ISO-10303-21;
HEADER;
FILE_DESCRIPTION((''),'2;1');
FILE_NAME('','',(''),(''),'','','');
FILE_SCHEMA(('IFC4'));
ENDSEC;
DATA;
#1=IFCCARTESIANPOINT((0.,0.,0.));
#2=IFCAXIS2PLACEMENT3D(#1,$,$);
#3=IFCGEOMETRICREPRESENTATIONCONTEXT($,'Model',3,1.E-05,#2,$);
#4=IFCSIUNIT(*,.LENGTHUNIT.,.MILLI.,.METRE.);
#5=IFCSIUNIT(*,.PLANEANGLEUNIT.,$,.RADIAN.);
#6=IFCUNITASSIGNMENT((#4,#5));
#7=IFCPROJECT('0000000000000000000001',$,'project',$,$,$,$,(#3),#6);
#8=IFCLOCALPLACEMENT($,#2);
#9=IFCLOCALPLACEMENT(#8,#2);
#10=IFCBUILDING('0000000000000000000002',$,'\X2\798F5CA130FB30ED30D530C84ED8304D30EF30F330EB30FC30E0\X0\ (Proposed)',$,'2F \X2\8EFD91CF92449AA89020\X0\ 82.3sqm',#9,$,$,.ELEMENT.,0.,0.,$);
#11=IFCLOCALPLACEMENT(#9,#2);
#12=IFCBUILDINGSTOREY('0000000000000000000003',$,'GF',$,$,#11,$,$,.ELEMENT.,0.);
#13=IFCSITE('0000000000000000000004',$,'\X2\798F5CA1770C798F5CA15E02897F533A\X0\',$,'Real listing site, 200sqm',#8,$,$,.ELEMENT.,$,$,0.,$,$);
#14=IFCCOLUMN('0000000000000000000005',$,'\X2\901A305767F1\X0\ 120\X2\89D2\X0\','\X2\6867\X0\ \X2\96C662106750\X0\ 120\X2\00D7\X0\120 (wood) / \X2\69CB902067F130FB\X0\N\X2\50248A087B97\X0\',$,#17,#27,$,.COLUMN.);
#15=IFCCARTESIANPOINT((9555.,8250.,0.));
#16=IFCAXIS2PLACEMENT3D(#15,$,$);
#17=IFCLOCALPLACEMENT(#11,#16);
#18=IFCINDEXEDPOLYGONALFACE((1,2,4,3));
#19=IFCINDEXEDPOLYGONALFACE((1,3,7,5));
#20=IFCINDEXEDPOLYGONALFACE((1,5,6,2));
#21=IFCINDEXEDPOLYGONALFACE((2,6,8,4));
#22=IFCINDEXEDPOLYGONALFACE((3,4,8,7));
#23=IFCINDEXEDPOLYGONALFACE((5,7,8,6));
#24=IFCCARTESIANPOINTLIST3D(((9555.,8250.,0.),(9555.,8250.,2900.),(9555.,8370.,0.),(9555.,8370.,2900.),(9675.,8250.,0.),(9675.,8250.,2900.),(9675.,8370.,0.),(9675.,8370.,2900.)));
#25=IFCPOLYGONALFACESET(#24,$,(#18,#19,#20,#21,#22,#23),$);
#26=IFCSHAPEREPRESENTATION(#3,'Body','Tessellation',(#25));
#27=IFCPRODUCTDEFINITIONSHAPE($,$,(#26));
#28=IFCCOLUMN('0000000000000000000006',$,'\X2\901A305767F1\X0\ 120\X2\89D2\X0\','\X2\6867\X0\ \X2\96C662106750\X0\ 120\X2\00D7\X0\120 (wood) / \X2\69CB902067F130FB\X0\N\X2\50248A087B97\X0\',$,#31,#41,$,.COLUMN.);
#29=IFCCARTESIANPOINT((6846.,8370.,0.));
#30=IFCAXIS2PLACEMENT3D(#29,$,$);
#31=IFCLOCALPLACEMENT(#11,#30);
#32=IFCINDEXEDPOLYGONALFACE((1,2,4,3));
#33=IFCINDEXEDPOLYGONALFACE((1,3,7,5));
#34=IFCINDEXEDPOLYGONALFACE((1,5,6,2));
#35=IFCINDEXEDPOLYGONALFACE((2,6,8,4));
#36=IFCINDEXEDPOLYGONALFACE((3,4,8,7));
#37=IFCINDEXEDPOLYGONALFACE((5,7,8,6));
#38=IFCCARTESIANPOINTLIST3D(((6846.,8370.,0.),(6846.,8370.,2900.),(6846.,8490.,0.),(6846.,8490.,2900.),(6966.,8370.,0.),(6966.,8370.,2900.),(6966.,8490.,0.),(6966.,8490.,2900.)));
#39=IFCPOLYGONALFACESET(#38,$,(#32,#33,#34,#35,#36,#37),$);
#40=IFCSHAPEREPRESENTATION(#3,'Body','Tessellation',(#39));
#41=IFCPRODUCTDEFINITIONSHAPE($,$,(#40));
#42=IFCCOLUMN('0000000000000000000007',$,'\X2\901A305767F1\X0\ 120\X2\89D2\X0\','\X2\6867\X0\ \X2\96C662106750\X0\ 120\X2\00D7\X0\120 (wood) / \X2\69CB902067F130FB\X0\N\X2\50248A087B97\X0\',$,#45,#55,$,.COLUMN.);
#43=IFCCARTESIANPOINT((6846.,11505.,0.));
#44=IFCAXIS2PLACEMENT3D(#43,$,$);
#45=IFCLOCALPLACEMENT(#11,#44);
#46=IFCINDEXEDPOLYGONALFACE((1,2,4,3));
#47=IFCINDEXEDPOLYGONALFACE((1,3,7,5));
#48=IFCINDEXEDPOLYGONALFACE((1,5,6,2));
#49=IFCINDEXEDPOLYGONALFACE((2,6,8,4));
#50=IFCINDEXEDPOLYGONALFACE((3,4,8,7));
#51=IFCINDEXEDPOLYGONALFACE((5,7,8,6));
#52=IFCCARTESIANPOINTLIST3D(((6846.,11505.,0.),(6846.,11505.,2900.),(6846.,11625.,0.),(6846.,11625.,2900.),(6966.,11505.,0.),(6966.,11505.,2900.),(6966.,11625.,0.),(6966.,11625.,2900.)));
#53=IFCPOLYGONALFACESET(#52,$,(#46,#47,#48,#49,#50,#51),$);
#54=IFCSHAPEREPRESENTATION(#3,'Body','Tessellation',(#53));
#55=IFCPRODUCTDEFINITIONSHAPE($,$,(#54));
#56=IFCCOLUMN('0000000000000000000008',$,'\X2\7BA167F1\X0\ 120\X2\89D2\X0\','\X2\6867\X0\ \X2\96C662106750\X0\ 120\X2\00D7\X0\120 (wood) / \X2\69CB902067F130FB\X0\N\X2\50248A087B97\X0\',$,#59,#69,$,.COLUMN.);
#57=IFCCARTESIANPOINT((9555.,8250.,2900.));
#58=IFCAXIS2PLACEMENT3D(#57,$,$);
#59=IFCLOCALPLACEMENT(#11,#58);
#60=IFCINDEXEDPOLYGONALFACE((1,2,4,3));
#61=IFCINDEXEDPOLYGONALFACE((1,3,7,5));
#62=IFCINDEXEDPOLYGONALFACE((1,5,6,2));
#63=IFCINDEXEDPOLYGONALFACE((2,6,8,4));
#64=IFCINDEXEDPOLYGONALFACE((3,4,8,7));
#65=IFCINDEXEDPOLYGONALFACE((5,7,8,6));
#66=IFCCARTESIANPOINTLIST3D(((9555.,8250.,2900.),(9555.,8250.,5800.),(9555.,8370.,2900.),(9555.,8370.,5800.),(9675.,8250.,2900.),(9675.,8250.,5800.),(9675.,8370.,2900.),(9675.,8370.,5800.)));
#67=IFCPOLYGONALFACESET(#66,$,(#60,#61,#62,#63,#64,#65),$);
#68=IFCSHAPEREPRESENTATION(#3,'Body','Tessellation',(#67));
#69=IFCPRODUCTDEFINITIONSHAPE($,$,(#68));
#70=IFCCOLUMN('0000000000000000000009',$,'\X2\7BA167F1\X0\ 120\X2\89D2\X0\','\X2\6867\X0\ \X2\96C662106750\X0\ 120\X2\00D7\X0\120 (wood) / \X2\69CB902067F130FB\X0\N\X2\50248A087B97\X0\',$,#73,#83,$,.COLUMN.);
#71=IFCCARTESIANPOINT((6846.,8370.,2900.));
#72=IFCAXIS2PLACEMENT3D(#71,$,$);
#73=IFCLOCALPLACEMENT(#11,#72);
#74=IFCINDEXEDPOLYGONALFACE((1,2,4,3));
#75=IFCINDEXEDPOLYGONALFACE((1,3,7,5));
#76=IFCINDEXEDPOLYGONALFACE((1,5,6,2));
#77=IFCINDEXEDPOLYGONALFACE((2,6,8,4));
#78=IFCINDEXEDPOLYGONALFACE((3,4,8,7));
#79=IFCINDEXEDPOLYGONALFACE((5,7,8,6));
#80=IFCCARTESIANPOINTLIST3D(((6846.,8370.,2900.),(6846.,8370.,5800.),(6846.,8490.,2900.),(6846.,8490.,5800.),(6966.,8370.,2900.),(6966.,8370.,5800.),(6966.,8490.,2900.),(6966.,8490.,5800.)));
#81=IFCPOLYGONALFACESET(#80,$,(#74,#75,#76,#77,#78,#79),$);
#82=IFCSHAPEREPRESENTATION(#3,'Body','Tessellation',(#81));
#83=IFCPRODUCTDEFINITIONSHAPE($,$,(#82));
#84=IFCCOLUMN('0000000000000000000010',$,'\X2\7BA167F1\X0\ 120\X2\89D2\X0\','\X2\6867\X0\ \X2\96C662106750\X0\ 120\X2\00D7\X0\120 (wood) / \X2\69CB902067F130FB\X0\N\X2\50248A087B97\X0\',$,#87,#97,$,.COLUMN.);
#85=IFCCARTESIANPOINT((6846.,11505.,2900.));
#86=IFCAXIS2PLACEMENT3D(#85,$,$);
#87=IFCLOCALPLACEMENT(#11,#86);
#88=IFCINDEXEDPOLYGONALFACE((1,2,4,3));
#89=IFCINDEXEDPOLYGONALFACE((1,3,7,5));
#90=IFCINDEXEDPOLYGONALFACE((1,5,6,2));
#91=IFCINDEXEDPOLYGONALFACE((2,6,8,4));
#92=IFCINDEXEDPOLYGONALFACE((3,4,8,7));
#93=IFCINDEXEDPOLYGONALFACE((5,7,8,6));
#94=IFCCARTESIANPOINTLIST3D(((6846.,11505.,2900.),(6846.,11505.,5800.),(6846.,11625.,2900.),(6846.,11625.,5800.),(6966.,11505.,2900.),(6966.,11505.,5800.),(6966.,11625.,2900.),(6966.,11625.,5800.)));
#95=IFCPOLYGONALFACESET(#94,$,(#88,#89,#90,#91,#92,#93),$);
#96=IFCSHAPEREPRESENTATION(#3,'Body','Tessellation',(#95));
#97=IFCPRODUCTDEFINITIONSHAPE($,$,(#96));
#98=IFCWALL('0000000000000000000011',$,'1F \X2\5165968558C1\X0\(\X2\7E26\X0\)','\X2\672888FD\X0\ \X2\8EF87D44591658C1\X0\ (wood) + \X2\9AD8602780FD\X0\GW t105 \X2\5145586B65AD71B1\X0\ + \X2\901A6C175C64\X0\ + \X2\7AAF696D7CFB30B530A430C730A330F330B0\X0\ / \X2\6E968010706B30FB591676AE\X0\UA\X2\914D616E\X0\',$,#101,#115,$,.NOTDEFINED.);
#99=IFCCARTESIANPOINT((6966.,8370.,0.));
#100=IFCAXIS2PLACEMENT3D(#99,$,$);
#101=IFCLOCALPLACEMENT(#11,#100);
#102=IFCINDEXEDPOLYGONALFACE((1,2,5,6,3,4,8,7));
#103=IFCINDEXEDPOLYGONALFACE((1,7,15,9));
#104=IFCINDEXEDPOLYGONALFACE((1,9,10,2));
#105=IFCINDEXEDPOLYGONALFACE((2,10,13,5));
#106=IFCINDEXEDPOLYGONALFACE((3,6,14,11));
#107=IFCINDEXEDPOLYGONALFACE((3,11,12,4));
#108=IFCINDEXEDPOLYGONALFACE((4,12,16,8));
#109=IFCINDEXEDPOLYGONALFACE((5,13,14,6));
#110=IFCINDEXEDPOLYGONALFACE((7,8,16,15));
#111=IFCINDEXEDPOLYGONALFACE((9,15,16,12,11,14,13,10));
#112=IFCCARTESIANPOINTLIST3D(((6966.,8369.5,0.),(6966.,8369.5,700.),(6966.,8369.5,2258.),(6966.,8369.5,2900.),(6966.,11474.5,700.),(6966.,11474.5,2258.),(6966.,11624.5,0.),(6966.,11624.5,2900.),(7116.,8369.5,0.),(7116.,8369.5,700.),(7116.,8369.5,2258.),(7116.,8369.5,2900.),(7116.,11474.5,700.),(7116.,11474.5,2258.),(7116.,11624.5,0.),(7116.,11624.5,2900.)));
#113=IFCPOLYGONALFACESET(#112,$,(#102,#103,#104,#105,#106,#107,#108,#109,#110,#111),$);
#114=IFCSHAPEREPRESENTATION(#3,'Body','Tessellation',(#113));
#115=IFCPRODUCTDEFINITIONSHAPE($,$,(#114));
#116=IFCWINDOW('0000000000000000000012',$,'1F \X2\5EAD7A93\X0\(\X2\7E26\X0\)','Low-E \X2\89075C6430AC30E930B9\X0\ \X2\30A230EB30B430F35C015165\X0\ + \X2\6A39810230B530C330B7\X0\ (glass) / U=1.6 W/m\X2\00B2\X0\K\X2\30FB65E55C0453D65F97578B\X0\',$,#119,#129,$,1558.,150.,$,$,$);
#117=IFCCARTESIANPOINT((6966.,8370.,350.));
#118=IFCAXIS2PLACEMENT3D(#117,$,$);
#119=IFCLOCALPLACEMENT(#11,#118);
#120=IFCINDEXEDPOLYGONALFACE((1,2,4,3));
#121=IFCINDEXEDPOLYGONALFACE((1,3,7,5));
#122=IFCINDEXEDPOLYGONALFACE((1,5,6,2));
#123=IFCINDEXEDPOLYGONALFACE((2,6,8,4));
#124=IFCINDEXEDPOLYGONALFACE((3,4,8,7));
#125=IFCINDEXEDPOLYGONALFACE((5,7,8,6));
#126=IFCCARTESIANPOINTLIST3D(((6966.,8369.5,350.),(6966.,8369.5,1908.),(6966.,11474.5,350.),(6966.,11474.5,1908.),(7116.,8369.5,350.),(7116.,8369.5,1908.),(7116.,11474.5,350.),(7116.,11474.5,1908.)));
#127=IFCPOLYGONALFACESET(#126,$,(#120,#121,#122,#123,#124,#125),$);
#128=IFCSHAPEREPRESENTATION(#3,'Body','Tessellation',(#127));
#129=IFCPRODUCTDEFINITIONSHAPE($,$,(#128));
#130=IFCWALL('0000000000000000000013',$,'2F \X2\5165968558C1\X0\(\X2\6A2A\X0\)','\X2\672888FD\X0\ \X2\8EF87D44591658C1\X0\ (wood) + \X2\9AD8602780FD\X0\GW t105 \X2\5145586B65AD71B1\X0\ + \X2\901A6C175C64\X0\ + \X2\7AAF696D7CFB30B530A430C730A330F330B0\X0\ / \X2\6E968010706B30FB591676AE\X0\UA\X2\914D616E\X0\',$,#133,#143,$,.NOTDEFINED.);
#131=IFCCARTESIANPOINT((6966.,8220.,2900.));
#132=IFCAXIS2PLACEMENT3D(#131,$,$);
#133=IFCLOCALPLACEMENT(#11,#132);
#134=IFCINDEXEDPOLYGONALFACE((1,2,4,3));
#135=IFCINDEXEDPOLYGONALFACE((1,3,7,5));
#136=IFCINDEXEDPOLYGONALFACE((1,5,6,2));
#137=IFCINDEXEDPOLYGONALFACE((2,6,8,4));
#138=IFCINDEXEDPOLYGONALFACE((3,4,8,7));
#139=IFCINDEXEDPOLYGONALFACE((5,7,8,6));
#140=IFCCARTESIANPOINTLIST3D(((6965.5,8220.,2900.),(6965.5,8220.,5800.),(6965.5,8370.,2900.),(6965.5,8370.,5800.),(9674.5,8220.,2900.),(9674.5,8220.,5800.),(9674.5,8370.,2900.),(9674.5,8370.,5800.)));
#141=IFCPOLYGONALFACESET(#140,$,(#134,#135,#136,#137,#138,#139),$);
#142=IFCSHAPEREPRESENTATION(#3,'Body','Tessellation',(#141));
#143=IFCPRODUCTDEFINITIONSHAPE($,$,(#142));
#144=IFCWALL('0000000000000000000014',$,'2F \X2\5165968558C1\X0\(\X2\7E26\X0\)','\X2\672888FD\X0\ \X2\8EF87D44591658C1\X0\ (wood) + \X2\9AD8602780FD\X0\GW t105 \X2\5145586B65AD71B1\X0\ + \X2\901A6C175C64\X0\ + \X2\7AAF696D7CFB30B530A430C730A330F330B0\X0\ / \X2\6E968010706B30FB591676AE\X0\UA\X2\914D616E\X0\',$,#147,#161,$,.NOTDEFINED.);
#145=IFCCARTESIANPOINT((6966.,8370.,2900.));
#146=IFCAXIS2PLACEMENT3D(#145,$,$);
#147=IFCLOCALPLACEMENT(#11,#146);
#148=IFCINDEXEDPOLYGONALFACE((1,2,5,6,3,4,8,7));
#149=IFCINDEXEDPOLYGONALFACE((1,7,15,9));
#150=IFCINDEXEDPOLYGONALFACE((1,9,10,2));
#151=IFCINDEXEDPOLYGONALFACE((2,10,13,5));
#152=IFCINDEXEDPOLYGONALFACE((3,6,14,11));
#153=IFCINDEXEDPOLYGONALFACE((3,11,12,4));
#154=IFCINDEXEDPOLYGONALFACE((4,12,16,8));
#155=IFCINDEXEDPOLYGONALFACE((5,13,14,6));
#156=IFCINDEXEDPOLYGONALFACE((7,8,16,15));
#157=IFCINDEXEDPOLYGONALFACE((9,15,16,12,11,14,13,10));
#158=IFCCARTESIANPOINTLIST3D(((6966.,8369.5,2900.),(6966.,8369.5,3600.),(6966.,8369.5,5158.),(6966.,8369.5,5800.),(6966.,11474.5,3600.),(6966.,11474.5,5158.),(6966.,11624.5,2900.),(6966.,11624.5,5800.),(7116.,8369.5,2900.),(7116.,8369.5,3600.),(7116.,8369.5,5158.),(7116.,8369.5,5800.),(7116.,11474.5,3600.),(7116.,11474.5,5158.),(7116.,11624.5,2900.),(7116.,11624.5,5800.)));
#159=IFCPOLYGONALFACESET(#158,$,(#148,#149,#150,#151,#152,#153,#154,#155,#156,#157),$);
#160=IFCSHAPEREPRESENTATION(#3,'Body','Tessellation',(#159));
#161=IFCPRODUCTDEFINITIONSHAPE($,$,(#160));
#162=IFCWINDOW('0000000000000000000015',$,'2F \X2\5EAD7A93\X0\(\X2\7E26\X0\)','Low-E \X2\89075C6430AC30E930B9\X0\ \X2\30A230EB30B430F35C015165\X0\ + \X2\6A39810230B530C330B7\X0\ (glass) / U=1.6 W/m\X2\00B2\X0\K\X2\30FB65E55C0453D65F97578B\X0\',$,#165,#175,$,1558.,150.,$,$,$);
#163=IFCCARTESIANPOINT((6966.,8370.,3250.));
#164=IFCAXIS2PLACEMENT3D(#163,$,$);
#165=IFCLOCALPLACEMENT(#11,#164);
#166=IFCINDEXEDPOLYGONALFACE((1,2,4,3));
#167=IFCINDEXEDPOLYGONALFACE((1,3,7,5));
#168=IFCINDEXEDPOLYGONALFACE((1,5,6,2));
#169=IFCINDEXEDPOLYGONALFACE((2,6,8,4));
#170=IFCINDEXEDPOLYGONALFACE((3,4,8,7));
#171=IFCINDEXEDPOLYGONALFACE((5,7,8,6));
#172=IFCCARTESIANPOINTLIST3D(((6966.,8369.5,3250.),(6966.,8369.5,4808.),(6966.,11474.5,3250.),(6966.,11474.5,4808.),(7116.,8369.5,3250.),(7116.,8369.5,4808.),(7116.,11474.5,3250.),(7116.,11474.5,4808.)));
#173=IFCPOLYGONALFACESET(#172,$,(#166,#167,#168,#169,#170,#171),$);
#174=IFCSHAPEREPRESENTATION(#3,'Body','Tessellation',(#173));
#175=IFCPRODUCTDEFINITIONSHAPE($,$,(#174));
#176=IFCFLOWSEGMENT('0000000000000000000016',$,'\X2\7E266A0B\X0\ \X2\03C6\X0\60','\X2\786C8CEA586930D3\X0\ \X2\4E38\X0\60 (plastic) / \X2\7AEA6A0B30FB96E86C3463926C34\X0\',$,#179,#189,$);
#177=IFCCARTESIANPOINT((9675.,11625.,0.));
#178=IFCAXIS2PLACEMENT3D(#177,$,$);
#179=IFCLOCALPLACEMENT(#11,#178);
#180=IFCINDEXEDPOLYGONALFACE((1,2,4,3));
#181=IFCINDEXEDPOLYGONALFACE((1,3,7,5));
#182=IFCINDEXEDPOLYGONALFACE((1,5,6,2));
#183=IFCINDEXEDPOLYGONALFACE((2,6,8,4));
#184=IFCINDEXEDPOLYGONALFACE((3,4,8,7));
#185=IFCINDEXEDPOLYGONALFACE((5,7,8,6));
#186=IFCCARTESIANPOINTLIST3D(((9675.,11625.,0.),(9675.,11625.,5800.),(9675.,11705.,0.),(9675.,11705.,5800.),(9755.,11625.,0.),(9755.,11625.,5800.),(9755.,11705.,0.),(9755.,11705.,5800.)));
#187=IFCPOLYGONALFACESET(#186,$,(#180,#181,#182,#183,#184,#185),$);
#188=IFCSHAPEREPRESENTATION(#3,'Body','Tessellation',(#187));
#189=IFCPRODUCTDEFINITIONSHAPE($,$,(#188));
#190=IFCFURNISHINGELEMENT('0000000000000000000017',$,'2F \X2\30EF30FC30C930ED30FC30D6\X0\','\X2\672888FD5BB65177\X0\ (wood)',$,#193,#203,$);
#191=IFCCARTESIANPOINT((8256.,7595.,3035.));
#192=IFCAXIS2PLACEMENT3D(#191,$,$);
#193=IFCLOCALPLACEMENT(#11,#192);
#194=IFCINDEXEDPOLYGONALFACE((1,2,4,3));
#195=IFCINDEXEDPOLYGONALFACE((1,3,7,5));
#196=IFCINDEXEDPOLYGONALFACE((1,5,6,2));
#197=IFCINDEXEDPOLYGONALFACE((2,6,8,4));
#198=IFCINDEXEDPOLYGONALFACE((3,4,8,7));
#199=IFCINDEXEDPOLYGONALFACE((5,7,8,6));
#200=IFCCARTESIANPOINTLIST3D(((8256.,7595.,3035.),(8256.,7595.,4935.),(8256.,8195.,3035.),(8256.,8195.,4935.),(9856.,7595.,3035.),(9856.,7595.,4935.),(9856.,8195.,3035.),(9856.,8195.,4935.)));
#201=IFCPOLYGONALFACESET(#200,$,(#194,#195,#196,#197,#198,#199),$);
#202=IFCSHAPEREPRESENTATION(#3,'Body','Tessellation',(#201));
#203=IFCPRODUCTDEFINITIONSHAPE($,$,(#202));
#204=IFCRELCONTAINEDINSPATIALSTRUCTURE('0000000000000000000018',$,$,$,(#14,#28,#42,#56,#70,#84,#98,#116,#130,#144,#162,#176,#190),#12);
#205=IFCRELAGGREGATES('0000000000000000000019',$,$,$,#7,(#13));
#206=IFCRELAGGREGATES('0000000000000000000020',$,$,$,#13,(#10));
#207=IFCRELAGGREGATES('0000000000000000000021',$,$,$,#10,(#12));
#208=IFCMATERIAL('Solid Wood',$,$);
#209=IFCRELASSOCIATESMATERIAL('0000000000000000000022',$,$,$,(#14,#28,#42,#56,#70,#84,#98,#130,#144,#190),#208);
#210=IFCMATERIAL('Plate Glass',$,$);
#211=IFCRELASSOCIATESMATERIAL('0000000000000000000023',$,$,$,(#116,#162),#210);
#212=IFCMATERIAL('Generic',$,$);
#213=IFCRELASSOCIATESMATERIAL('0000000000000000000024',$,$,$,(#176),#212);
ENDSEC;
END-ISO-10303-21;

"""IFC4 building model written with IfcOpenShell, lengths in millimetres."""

from ifc_helpers import new_model, si_unit, frame, frame_2d, origin, place, context, project, spatial, rectangle, extrude, material, element, fill, save


model = new_model("IFC4")

# Units and contexts
model_context = context("Model", 3, precision=1e-05, world=origin())
ifc_project = project(units=[si_unit("LENGTHUNIT", "METRE", prefix="MILLI"), si_unit("PLANEANGLEUNIT", "RADIAN")], contexts=[model_context])

# Site, building, storey
site_placement = place(None, origin())
site = spatial("IfcSite", under=ifc_project, at=site_placement, Name="福岡県福岡市西区", ObjectType="Real listing site, 200sqm", CompositionType="ELEMENT", RefElevation=0.0)
building_placement = place(site_placement, origin())
building = spatial("IfcBuilding", under=site, at=building_placement, Name="福岡・ロフト付きワンルーム (Proposed)", ObjectType="2F 軽量鉄骨造 82.3sqm", CompositionType="ELEMENT", ElevationOfRefHeight=0.0, ElevationOfTerrain=0.0)
storey_placement = place(building_placement, origin())
storey = spatial("IfcBuildingStorey", under=building, at=storey_placement, Name="GF", CompositionType="ELEMENT", Elevation=0.0)

# Columns
ifc_material_1 = material(Name="Solid Wood")
column_1_placement = place(storey_placement, frame((9555.0, 8250.0, 0.0)))
element("IfcColumn", 1, at=column_1_placement, inside=storey, material=ifc_material_1, Name="通し柱 120角", Description="桧 集成材 120×120 (wood) / 構造柱・N値計算", PredefinedType="COLUMN", context=model_context, shape_type="SweptSolid", body=[
    extrude(rectangle(XDim=120.0, YDim=120.0, at=frame_2d((60.0, 60.0))), frame((9555.0, 8250.0, 0.0)), (0.0, 0.0, 1.0), 2900.0),
])
column_2_placement = place(storey_placement, frame((6846.0, 8370.0, 0.0)))
element("IfcColumn", 2, at=column_2_placement, inside=storey, material=ifc_material_1, Name="通し柱 120角", Description="桧 集成材 120×120 (wood) / 構造柱・N値計算", PredefinedType="COLUMN", context=model_context, shape_type="SweptSolid", body=[
    extrude(rectangle(XDim=120.0, YDim=120.0, at=frame_2d((60.0, 60.0))), frame((6846.0, 8370.0, 0.0)), (0.0, 0.0, 1.0), 2900.0),
])
column_3_placement = place(storey_placement, frame((6846.0, 11505.0, 0.0)))
element("IfcColumn", 3, at=column_3_placement, inside=storey, material=ifc_material_1, Name="通し柱 120角", Description="桧 集成材 120×120 (wood) / 構造柱・N値計算", PredefinedType="COLUMN", context=model_context, shape_type="SweptSolid", body=[
    extrude(rectangle(XDim=120.0, YDim=120.0, at=frame_2d((60.0, 60.0))), frame((6846.0, 11505.0, 0.0)), (0.0, 0.0, 1.0), 2900.0),
])
column_4_placement = place(storey_placement, frame((9555.0, 8250.0, 2900.0)))
element("IfcColumn", 4, at=column_4_placement, inside=storey, material=ifc_material_1, Name="管柱 120角", Description="桧 集成材 120×120 (wood) / 構造柱・N値計算", PredefinedType="COLUMN", context=model_context, shape_type="SweptSolid", body=[
    extrude(rectangle(XDim=120.0, YDim=120.0, at=frame_2d((60.0, 60.0))), frame((9555.0, 8250.0, 2900.0)), (0.0, 0.0, 1.0), 2900.0),
])
column_5_placement = place(storey_placement, frame((6846.0, 8370.0, 2900.0)))
element("IfcColumn", 5, at=column_5_placement, inside=storey, material=ifc_material_1, Name="管柱 120角", Description="桧 集成材 120×120 (wood) / 構造柱・N値計算", PredefinedType="COLUMN", context=model_context, shape_type="SweptSolid", body=[
    extrude(rectangle(XDim=120.0, YDim=120.0, at=frame_2d((60.0, 60.0))), frame((6846.0, 8370.0, 2900.0)), (0.0, 0.0, 1.0), 2900.0),
])
column_6_placement = place(storey_placement, frame((6846.0, 11505.0, 2900.0)))
element("IfcColumn", 6, at=column_6_placement, inside=storey, material=ifc_material_1, Name="管柱 120角", Description="桧 集成材 120×120 (wood) / 構造柱・N値計算", PredefinedType="COLUMN", context=model_context, shape_type="SweptSolid", body=[
    extrude(rectangle(XDim=120.0, YDim=120.0, at=frame_2d((60.0, 60.0))), frame((6846.0, 11505.0, 2900.0)), (0.0, 0.0, 1.0), 2900.0),
])

# Wall, opening, window
wall_1_placement = place(storey_placement, frame((6966.0, 8370.0, 0.0)))
wall_1 = element("IfcWall", 7, at=wall_1_placement, inside=storey, material=ifc_material_1, Name="1F 入隅壁(縦)", Description="木製 軸組外壁 (wood) + 高性能GW t105 充填断熱 + 通気層 + 窯業系サイディング / 準耐火・外皮UA配慮", PredefinedType="NOTDEFINED", context=model_context, shape_type="SweptSolid", body=[
    extrude(rectangle(XDim=150.0, YDim=3255.0, at=frame_2d((75.0, 1627.0))), frame((6966.0, 8370.0, 0.0)), (0.0, 0.0, 1.0), 2900.0),
])
opening_1_placement = place(storey_placement, frame((6966.0, 8370.0, 350.0)))
opening_1 = element("IfcOpeningElement", 8, at=opening_1_placement, cuts=wall_1, PredefinedType="NOTDEFINED", context=model_context, shape_type="SweptSolid", body=[
    extrude(rectangle(XDim=150.0, YDim=3105.0, at=frame_2d((75.0, 1552.0))), frame((6966.0, 8370.0, 350.0)), (0.0, 0.0, 1.0), 1558.0),
])
ifc_material_2 = material(Name="Plate Glass")
window_1_placement = place(storey_placement, frame((6966.0, 8370.0, 350.0)))
window_1 = element("IfcWindow", 9, at=window_1_placement, inside=storey, material=ifc_material_2, Name="1F 庭窓(縦)", Description="Low-E 複層ガラス アルゴン封入 + 樹脂サッシ (glass) / U=1.6 W/m²K・日射取得型", OverallHeight=1558.0, OverallWidth=150.0, context=model_context, shape_type="SweptSolid", body=[
    extrude(rectangle(XDim=150.0, YDim=3105.0, at=frame_2d((75.0, 1552.0))), frame((6966.0, 8370.0, 350.0)), (0.0, 0.0, 1.0), 1558.0),
])
fill(opening_1, window_1)

# Wall
wall_2_placement = place(storey_placement, frame((6966.0, 8220.0, 2900.0)))
element("IfcWall", 10, at=wall_2_placement, inside=storey, material=ifc_material_1, Name="2F 入隅壁(横)", Description="木製 軸組外壁 (wood) + 高性能GW t105 充填断熱 + 通気層 + 窯業系サイディング / 準耐火・外皮UA配慮", PredefinedType="NOTDEFINED", context=model_context, shape_type="SweptSolid", body=[
    extrude(rectangle(XDim=2709.0, YDim=150.0, at=frame_2d((1354.0, 75.0))), frame((6966.0, 8220.0, 2900.0)), (0.0, 0.0, 1.0), 2900.0),
])

# Wall, opening, window
wall_3_placement = place(storey_placement, frame((6966.0, 8370.0, 2900.0)))
wall_3 = element("IfcWall", 11, at=wall_3_placement, inside=storey, material=ifc_material_1, Name="2F 入隅壁(縦)", Description="木製 軸組外壁 (wood) + 高性能GW t105 充填断熱 + 通気層 + 窯業系サイディング / 準耐火・外皮UA配慮", PredefinedType="NOTDEFINED", context=model_context, shape_type="SweptSolid", body=[
    extrude(rectangle(XDim=150.0, YDim=3255.0, at=frame_2d((75.0, 1627.0))), frame((6966.0, 8370.0, 2900.0)), (0.0, 0.0, 1.0), 2900.0),
])
opening_2_placement = place(storey_placement, frame((6966.0, 8370.0, 3250.0)))
opening_2 = element("IfcOpeningElement", 12, at=opening_2_placement, cuts=wall_3, PredefinedType="NOTDEFINED", context=model_context, shape_type="SweptSolid", body=[
    extrude(rectangle(XDim=150.0, YDim=3105.0, at=frame_2d((75.0, 1552.0))), frame((6966.0, 8370.0, 3250.0)), (0.0, 0.0, 1.0), 1558.0),
])
window_2_placement = place(storey_placement, frame((6966.0, 8370.0, 3250.0)))
window_2 = element("IfcWindow", 13, at=window_2_placement, inside=storey, material=ifc_material_2, Name="2F 庭窓(縦)", Description="Low-E 複層ガラス アルゴン封入 + 樹脂サッシ (glass) / U=1.6 W/m²K・日射取得型", OverallHeight=1558.0, OverallWidth=150.0, context=model_context, shape_type="SweptSolid", body=[
    extrude(rectangle(XDim=150.0, YDim=3105.0, at=frame_2d((75.0, 1552.0))), frame((6966.0, 8370.0, 3250.0)), (0.0, 0.0, 1.0), 1558.0),
])
fill(opening_2, window_2)

# Flow segment
ifc_material_3 = material(Name="Generic")
flow_segment_placement = place(storey_placement, frame((9675.0, 11625.0, 0.0)))
element("IfcFlowSegment", 14, at=flow_segment_placement, inside=storey, material=ifc_material_3, Name="縦樋 φ60", Description="硬質塩ビ 丸60 (plastic) / 竪樋・雨水排水", context=model_context, shape_type="SweptSolid", body=[
    extrude(rectangle(XDim=80.0, YDim=80.0, at=frame_2d((40.0, 40.0))), frame((9675.0, 11625.0, 0.0)), (0.0, 0.0, 1.0), 5800.0),
])

# Furnishing element
furnishing_placement = place(storey_placement, frame((8256.0, 7595.0, 3035.0)))
element("IfcFurnishingElement", 15, at=furnishing_placement, inside=storey, material=ifc_material_1, Name="2F ワードローブ", Description="木製家具 (wood)", context=model_context, shape_type="SweptSolid", body=[
    extrude(rectangle(XDim=1600.0, YDim=600.0, at=frame_2d((800.0, 300.0))), frame((8256.0, 7595.0, 3035.0)), (0.0, 0.0, 1.0), 1900.0),
])

save(model, "model.ifc")
